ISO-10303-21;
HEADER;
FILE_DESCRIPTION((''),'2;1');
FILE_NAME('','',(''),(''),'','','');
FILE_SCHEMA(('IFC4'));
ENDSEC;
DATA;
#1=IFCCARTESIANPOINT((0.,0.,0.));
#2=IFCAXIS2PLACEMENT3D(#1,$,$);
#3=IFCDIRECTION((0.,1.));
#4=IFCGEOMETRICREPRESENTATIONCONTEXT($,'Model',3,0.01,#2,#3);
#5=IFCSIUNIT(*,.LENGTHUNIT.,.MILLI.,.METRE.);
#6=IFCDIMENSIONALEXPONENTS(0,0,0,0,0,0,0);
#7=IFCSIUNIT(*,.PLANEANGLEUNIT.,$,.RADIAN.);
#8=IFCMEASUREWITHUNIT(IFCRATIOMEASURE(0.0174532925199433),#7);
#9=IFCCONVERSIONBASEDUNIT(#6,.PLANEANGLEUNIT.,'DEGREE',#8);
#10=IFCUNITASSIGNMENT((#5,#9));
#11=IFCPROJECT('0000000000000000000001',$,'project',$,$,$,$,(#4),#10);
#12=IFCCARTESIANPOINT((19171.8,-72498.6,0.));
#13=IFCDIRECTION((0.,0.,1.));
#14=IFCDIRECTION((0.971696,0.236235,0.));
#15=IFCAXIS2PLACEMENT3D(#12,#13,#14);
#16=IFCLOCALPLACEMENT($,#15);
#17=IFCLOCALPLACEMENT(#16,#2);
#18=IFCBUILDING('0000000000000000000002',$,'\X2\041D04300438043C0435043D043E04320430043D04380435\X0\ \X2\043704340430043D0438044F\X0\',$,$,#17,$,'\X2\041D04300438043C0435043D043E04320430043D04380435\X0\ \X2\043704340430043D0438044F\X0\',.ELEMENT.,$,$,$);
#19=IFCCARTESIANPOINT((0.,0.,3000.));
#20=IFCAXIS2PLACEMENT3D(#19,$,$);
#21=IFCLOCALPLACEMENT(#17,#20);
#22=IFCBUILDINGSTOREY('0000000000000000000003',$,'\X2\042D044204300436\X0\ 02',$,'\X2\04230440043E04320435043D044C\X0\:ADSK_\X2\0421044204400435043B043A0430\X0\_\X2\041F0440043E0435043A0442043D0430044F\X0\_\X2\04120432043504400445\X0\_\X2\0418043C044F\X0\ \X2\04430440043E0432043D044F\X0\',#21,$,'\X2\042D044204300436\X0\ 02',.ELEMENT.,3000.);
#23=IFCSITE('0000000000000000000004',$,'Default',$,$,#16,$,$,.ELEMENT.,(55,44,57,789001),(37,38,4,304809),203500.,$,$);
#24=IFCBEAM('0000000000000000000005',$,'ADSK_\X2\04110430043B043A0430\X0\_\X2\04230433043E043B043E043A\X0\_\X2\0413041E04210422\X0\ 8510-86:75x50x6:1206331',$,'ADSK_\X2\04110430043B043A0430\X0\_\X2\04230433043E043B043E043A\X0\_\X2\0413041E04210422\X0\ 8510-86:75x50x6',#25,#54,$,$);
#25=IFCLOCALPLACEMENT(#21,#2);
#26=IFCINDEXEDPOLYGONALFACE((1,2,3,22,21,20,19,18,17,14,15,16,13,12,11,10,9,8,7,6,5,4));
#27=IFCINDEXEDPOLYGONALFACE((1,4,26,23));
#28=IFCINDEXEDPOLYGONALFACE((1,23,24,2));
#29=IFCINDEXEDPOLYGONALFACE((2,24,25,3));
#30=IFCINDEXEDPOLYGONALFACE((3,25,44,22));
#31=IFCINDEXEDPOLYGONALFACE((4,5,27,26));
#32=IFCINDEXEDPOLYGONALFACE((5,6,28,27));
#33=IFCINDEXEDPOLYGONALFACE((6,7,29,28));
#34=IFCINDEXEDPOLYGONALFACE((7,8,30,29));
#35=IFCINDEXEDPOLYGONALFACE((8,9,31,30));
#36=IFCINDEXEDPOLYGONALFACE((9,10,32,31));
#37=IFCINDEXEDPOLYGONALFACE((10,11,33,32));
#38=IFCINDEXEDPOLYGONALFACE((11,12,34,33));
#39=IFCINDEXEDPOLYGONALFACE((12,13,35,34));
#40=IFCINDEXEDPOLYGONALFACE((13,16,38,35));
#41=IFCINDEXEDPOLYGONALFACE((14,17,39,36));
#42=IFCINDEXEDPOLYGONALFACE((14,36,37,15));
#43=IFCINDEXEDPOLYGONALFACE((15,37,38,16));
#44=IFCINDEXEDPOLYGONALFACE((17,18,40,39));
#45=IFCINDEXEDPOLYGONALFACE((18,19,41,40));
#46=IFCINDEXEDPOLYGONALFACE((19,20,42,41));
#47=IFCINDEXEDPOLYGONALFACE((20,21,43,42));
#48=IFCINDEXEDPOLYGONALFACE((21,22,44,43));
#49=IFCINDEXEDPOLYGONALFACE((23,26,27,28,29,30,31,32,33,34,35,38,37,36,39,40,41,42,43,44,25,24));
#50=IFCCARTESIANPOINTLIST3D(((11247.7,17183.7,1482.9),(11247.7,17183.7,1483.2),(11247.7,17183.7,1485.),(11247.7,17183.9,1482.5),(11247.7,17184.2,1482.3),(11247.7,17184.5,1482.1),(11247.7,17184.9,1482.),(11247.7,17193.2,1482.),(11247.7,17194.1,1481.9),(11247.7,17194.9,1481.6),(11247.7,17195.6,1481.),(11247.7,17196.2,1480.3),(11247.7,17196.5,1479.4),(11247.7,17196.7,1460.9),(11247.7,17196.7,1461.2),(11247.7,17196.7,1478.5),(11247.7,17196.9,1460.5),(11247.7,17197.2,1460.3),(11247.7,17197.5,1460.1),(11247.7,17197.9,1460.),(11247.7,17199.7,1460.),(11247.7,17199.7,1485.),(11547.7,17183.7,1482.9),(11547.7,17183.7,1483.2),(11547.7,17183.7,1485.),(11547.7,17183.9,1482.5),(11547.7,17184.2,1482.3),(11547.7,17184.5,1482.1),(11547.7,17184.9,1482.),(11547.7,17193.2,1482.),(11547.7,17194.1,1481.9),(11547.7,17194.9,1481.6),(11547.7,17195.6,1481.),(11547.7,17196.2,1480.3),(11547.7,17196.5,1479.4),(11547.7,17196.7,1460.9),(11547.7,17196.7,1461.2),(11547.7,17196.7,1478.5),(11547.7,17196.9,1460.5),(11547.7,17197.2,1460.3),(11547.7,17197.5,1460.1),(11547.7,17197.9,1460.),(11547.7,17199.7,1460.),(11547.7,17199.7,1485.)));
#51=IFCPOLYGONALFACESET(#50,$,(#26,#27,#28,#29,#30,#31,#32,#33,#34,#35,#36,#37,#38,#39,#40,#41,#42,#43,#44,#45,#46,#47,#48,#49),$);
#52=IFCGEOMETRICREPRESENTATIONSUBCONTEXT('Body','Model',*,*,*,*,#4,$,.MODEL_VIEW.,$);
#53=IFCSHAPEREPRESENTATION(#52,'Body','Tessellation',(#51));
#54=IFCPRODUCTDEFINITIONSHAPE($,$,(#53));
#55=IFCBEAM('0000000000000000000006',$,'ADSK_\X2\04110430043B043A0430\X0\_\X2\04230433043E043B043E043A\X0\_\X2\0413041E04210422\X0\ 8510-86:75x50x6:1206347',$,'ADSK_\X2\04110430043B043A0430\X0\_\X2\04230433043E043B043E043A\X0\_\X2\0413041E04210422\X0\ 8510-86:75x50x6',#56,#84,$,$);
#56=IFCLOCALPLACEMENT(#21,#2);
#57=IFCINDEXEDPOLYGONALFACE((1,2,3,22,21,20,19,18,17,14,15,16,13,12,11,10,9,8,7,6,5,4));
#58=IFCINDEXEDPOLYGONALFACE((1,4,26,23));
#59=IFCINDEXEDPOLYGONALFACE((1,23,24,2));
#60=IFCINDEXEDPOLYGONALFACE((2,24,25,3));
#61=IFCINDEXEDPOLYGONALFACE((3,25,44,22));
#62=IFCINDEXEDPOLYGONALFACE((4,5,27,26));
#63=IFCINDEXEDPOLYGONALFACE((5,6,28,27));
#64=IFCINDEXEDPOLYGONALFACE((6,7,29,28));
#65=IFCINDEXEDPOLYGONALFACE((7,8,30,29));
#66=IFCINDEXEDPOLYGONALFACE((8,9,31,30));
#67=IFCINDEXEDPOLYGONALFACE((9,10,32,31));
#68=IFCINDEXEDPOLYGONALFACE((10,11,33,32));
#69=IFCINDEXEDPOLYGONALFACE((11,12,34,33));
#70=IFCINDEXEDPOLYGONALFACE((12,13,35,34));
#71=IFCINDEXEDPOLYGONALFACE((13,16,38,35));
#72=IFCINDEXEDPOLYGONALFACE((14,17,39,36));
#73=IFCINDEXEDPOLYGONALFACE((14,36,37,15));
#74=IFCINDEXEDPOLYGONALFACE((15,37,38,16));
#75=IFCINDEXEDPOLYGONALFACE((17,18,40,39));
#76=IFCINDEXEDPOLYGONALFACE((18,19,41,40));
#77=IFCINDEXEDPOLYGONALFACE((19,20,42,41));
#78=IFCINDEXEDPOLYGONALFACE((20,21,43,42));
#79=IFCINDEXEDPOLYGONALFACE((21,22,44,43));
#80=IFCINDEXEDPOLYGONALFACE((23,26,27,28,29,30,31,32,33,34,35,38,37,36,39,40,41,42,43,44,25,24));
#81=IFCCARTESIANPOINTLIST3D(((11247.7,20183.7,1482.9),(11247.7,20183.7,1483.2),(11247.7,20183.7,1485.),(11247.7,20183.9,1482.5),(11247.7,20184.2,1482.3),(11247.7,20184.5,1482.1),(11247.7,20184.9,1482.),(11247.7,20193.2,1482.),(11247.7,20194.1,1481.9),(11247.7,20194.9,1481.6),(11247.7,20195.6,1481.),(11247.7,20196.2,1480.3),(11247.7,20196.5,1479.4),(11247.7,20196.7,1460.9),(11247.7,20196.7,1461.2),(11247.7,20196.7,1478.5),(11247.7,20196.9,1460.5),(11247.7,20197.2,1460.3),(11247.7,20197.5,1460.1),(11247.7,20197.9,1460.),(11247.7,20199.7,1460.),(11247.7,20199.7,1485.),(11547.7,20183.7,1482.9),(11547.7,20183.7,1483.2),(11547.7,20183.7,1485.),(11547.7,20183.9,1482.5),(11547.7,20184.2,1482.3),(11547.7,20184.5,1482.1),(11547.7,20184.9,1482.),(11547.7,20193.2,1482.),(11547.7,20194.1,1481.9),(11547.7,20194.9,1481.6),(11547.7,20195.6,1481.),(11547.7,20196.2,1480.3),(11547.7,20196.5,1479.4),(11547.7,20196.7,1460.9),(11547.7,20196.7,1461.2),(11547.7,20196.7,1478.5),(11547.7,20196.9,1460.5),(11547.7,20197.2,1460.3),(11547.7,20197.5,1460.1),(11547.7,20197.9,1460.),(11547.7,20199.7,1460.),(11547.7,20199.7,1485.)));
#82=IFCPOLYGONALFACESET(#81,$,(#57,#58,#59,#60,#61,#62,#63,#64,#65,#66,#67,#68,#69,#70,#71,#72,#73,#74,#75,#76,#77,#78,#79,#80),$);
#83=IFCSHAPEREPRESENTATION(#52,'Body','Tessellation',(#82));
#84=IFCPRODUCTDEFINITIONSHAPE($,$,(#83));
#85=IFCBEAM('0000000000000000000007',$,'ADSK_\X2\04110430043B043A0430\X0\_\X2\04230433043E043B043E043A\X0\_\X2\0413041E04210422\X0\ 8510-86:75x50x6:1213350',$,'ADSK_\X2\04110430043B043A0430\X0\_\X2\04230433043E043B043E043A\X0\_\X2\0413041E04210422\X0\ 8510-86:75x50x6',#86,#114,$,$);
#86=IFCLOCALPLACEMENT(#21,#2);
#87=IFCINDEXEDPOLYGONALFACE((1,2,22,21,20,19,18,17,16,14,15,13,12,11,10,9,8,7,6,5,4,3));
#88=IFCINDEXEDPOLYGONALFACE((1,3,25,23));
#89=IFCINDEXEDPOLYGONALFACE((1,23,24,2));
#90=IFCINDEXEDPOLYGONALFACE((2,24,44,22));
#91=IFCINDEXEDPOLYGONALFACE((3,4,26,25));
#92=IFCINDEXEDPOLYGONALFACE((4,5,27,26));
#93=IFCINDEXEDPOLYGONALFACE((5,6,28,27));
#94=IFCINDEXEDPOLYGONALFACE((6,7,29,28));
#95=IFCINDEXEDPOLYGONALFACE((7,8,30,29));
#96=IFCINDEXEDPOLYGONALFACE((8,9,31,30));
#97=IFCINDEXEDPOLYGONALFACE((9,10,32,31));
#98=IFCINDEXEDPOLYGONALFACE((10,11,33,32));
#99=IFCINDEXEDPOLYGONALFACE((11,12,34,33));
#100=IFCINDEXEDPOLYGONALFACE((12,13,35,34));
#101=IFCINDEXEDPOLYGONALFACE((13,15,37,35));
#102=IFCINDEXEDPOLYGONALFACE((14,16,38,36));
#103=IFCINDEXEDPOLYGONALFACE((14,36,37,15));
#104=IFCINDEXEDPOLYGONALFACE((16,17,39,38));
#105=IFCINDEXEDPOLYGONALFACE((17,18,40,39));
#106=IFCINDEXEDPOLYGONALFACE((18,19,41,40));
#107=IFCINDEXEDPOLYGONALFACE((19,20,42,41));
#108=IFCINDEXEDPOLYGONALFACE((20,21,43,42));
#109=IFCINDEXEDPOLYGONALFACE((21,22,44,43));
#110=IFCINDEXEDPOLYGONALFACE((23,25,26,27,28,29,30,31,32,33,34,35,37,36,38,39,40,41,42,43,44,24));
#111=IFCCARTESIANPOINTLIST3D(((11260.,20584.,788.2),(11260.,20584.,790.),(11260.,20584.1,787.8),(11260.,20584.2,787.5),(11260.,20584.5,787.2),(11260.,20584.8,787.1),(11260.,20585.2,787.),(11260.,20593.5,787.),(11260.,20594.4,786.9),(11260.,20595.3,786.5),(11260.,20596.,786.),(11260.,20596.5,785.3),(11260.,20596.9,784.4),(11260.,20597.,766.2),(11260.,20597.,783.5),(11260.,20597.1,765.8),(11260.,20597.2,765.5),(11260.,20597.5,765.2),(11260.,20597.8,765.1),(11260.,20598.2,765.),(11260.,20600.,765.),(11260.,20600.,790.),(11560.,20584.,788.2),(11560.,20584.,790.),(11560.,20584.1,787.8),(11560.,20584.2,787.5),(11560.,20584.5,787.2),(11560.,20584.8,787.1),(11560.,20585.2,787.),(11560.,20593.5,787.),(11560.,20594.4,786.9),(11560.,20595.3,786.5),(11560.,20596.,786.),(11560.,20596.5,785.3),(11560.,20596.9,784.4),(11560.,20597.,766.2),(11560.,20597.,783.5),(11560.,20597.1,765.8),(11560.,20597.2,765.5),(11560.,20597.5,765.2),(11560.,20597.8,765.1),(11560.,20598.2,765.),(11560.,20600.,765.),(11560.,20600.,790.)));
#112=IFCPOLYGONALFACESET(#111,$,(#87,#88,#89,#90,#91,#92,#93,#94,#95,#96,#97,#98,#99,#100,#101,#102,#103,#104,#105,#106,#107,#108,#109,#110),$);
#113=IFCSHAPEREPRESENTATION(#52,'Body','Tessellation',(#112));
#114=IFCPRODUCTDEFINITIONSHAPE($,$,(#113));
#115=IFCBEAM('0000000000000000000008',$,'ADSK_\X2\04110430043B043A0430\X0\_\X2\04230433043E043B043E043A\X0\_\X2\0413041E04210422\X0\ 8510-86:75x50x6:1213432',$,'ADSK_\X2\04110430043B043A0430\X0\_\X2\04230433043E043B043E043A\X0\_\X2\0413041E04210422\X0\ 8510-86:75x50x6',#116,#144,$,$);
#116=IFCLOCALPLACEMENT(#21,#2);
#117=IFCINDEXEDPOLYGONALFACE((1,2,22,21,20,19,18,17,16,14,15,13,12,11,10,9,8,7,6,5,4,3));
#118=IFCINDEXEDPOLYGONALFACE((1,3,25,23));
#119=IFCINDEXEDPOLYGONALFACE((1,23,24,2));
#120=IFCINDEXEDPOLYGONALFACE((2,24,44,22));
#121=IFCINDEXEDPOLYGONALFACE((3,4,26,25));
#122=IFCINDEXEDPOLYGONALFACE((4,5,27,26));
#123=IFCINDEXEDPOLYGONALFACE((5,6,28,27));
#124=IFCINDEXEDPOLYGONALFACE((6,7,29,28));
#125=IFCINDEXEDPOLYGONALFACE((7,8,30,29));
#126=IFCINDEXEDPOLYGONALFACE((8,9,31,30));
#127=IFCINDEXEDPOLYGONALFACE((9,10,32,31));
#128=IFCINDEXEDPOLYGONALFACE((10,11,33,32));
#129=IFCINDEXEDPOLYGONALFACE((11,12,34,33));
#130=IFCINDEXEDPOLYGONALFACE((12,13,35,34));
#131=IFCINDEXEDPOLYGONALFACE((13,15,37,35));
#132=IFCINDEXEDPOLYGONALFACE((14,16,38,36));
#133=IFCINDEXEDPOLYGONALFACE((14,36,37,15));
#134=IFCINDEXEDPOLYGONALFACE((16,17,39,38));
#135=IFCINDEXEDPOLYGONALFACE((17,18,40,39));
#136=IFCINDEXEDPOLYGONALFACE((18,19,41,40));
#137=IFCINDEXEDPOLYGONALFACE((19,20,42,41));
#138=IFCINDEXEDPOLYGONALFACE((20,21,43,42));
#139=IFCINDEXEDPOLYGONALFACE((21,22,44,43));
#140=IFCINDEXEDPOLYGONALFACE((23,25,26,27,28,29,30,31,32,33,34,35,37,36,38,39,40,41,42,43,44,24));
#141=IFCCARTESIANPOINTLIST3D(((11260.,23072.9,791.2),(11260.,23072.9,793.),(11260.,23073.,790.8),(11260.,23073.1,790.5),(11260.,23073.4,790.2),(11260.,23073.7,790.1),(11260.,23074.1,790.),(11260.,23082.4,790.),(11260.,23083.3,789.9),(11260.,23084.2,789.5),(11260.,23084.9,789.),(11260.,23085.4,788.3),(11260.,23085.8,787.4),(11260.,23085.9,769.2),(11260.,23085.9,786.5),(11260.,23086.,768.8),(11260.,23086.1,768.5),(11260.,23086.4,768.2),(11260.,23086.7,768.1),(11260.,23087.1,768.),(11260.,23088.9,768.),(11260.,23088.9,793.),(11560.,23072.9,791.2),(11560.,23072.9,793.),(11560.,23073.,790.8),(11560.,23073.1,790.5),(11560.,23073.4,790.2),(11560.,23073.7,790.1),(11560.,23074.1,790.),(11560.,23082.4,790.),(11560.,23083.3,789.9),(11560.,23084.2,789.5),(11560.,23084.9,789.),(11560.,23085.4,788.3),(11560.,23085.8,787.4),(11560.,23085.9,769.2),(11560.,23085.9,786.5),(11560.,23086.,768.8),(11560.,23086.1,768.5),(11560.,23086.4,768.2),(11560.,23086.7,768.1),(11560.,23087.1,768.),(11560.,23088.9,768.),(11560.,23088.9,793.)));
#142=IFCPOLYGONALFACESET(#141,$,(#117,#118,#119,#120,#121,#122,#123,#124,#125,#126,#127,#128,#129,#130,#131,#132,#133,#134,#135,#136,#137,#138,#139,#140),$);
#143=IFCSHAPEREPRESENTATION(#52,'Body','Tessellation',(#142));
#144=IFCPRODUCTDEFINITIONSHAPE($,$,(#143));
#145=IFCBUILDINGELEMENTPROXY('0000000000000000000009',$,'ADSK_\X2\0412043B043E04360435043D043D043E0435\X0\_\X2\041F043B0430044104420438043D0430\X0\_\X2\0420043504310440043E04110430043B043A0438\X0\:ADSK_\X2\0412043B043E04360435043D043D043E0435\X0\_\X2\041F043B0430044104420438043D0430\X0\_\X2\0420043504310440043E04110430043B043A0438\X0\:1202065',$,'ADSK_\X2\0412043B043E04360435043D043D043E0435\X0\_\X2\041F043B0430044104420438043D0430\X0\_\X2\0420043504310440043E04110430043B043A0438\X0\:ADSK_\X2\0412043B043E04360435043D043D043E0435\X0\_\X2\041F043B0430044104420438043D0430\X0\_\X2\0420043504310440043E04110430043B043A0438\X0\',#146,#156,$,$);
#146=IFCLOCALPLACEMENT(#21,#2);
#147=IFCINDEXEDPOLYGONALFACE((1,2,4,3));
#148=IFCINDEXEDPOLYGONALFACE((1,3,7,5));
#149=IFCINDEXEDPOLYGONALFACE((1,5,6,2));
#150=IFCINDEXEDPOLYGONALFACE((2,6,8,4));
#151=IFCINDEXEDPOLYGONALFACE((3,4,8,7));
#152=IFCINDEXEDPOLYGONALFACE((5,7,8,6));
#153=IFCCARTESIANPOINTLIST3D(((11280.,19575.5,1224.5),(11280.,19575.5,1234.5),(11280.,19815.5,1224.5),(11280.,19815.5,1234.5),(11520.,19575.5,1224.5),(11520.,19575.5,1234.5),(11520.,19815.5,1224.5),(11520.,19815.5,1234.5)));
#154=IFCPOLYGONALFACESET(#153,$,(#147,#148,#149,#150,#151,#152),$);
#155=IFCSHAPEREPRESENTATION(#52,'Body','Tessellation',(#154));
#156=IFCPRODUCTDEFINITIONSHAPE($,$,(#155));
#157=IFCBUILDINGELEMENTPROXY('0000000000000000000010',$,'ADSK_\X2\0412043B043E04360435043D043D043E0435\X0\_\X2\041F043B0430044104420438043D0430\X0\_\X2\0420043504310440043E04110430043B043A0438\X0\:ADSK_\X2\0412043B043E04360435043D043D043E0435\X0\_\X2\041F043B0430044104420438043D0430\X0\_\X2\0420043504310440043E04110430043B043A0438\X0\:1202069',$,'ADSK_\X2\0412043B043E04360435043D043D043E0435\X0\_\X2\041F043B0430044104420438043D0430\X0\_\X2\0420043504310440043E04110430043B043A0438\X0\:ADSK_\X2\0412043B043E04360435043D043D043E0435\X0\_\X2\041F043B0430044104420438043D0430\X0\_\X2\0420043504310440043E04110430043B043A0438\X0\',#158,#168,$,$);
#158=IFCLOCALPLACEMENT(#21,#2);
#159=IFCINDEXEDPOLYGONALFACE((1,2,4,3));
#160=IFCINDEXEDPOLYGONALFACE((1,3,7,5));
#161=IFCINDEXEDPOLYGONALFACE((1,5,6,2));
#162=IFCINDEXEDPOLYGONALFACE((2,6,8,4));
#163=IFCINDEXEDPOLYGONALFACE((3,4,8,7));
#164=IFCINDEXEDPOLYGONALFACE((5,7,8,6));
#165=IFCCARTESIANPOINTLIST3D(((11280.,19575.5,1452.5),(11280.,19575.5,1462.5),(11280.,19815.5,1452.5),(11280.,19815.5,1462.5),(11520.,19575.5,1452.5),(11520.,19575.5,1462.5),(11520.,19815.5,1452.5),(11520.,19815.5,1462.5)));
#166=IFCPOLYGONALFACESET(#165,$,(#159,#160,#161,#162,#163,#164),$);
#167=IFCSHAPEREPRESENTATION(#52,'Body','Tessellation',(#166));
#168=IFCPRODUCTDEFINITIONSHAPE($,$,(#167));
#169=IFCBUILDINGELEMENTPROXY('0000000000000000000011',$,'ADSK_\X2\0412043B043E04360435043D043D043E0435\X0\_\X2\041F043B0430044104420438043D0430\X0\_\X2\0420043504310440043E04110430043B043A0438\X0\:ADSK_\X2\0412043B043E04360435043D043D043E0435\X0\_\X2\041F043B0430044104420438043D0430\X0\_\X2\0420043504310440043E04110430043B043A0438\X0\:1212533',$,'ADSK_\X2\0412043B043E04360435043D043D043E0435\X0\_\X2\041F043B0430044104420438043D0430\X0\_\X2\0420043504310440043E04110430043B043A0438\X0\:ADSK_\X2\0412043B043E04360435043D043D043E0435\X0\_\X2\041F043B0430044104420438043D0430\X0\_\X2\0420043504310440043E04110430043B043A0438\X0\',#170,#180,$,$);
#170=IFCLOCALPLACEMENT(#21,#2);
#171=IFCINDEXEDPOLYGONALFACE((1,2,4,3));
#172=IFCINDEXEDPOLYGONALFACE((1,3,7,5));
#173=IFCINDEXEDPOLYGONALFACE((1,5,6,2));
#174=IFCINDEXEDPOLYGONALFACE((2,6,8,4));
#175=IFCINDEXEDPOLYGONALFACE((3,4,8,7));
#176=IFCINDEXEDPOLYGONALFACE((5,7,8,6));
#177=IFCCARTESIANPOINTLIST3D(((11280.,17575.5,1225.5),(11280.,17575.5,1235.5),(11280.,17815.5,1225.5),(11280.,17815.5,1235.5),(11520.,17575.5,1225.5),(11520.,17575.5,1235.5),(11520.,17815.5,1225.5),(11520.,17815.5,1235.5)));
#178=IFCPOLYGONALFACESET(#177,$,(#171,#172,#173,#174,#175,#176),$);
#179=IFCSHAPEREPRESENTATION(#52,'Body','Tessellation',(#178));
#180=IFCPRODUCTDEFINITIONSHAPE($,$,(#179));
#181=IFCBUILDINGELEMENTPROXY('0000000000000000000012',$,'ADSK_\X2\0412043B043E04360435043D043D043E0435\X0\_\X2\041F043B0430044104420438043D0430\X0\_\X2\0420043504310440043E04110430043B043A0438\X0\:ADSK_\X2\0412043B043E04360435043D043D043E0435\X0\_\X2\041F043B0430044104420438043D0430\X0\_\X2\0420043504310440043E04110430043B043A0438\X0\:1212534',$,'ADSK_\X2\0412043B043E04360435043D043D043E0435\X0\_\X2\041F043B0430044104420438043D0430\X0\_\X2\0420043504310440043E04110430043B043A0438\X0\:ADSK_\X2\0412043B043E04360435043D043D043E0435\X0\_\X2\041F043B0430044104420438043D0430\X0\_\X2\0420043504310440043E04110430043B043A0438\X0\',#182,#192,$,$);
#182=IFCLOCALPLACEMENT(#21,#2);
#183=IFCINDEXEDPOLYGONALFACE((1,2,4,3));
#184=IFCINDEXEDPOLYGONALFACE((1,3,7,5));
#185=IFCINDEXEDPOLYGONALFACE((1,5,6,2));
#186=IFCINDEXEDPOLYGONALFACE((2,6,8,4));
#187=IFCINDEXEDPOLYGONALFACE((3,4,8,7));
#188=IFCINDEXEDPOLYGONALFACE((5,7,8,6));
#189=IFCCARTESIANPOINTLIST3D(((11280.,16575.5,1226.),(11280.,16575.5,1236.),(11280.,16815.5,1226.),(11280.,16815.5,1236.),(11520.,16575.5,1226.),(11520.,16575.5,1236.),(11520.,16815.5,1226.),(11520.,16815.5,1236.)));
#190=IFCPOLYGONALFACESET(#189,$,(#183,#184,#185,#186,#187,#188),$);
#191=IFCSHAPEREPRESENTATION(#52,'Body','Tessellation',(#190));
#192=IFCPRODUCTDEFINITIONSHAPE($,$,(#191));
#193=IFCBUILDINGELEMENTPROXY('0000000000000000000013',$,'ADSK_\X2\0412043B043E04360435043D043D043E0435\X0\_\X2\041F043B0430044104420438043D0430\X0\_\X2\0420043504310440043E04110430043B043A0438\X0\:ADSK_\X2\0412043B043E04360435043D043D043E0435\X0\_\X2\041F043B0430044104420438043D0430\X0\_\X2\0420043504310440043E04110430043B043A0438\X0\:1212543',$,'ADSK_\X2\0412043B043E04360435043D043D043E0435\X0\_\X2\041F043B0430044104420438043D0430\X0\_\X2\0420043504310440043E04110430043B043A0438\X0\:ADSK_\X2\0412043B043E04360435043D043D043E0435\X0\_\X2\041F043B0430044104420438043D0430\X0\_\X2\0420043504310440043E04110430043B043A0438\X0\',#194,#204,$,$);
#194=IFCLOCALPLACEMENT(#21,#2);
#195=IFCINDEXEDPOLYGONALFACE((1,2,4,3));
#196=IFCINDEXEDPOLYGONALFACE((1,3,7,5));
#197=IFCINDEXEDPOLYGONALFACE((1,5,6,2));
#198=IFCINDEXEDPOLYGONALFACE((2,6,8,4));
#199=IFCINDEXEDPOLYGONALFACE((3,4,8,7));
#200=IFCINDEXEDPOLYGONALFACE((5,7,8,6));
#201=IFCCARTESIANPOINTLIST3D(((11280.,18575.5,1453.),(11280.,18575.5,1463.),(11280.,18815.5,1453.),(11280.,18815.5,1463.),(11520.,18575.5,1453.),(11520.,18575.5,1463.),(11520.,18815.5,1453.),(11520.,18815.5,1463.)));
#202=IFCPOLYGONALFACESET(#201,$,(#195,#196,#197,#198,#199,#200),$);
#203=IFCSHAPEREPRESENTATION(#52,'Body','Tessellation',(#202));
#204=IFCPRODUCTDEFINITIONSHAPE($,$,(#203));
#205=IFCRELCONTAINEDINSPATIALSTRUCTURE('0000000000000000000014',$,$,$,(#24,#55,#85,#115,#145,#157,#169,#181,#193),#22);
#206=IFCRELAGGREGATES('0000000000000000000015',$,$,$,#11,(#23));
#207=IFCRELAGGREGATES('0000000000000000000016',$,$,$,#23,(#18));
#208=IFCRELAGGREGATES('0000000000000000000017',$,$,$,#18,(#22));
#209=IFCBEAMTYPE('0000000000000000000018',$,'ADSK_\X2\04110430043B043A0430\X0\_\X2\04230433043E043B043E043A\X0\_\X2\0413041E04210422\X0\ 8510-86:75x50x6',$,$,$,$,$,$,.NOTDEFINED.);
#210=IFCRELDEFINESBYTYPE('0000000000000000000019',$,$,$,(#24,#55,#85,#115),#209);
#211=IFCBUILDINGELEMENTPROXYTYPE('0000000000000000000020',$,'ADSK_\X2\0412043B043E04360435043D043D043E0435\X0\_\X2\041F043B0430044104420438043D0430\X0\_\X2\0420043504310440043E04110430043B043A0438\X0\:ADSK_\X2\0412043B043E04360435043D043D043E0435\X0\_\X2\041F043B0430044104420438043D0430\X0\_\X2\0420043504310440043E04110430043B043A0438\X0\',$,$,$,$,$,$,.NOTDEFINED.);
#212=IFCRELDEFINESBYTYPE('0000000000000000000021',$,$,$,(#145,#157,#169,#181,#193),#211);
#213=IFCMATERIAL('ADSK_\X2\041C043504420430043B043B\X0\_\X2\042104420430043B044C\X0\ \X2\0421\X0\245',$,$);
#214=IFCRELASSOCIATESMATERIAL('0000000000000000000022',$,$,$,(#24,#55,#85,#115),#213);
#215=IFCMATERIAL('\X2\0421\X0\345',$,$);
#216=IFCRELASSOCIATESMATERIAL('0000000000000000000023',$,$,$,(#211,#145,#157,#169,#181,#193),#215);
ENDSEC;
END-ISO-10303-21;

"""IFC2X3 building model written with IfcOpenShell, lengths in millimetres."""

from ifc_helpers import new_model, entity, si_unit, converted_unit, direction, frame, frame_2d, origin, origin_2d_with_axis, place, context, subcontext, project, spatial, polyline, circle_curve, parameter, trimmed, segment, composite_curve, rectangle, outline, extrude, source, transform, mapped, material, type_object, type_shapes, element, save


model = new_model("IFC2X3")

# Units and contexts
model_context = context("Model", 3, precision=0.01, world=origin(), true_north=direction((0.0, 1.0)))
body_context = subcontext(model_context, "Body", "Model", "MODEL_VIEW")
ifc_project = project(units=[si_unit("LENGTHUNIT", "METRE", prefix="MILLI"), converted_unit("PLANEANGLEUNIT", "DEGREE", entity("IfcRatioMeasure", 0.0174532925199433), si_unit("PLANEANGLEUNIT", "RADIAN"), dimensions=[0, 0, 0, 0, 0, 0, 0])], contexts=[model_context])

# Site, building, storey
site_placement = place(None, frame((19171.8, -72498.6, 0.0), z_axis=(0.0, 0.0, 1.0), x_axis=(0.971696, 0.236235, 0.0)))
site = spatial("IfcSite", under=ifc_project, at=site_placement, Name="Default", CompositionType="ELEMENT", RefLatitude=(55, 44, 57, 789001), RefLongitude=(37, 38, 4, 304809), RefElevation=203500.0)
building_placement = place(site_placement, origin())
building = spatial("IfcBuilding", under=site, at=building_placement, Name="Наименование здания", LongName="Наименование здания", CompositionType="ELEMENT")
storey_placement = place(building_placement, frame((0.0, 0.0, 3000.0)))
storey = spatial("IfcBuildingStorey", under=building, at=storey_placement, Name="Этаж 02", ObjectType="Уровень:ADSK_Стрелка_Проектная_Вверх_Имя уровня", LongName="Этаж 02", CompositionType="ELEMENT", Elevation=3000.0)

# Beams
ifc_material_1 = material(Name="ADSK_Металл_Сталь С245")
beam_type_1 = type_object("IfcBeamType", Name="ADSK_Балка_Уголок_ГОСТ 8510-86:75x50x6", PredefinedType="NOTDEFINED")
beam_1_placement = place(storey_placement, frame((11247.7, 17195.5, 1460.0)))
element("IfcBeam", 1, at=beam_1_placement, inside=storey, type_object=beam_type_1, material=ifc_material_1, Name="ADSK_Балка_Уголок_ГОСТ 8510-86:75x50x6:1206331", ObjectType="ADSK_Балка_Уголок_ГОСТ 8510-86:75x50x6", context=body_context, shape_type="SweptSolid", body=[
    extrude(outline(composite_curve([segment(polyline([(-9.8, -9.2), (-8.0, -9.2)]), True, "CONTINUOUS"), segment(trimmed(circle_curve(frame_2d((-8.0, -8.0), x_axis=(0.0, -1.0)), 1.2), [parameter(0.0)], [parameter(90.0)], True, "PARAMETER"), True, "CONTINUOUS"), segment(polyline([(-6.8, -8.0), (-6.8, 0.3)]), True, "CONTINUOUS"), segment(trimmed(circle_curve(frame_2d((-3.3, 0.3), x_axis=(-1.0, 0.0)), 3.5), [parameter(270.0)], [parameter(0.0)], True, "PARAMETER"), False, "CONTINUOUS"), segment(polyline([(-3.3, 3.8), (14.0, 3.8)]), True, "CONTINUOUS"), segment(trimmed(circle_curve(frame_2d((14.0, 5.0), x_axis=(0.0, -1.0)), 1.2), [parameter(0.0)], [parameter(90.0)], True, "PARAMETER"), True, "CONTINUOUS"), segment(polyline([(15.2, 5.0), (15.2, 6.8)]), True, "CONTINUOUS"), segment(polyline([(15.2, 6.8), (-9.8, 6.8)]), True, "CONTINUOUS"), segment(polyline([(-9.8, 6.8), (-9.8, -9.2)]), True, "CONTINUOUS")], self_intersect=False)), frame((0.0, -2.6, 15.2), z_axis=(1.0, 0.0, 0.0), x_axis=(0.0, 0.0, -1.0)), (0.0, 0.0, 1.0), 300.0),
])
for number, where, name in (
    (2, (11247.7, 20195.5, 1460.0), "ADSK_Балка_Уголок_ГОСТ 8510-86:75x50x6:1206347"),
    (3, (11260.0, 20595.8, 765.0), "ADSK_Балка_Уголок_ГОСТ 8510-86:75x50x6:1213350"),
    (4, (11260.0, 23084.7, 768.0), "ADSK_Балка_Уголок_ГОСТ 8510-86:75x50x6:1213432"),
):
    element("IfcBeam", number, at=place(storey_placement, frame(where)), inside=storey, type_object=beam_type_1, material=ifc_material_1, Name=name, ObjectType="ADSK_Балка_Уголок_ГОСТ 8510-86:75x50x6", context=body_context, shape_type="SweptSolid", body=[
        extrude(outline(composite_curve([segment(polyline([(-9.8, -9.2), (-8.0, -9.2)]), True, "CONTINUOUS"), segment(trimmed(circle_curve(frame_2d((-8.0, -8.0), x_axis=(0.0, -1.0)), 1.2), [parameter(0.0)], [parameter(90.0)], True, "PARAMETER"), True, "CONTINUOUS"), segment(polyline([(-6.8, -8.0), (-6.8, 0.3)]), True, "CONTINUOUS"), segment(trimmed(circle_curve(frame_2d((-3.3, 0.3), x_axis=(-1.0, 0.0)), 3.5), [parameter(270.0)], [parameter(0.0)], True, "PARAMETER"), False, "CONTINUOUS"), segment(polyline([(-3.3, 3.8), (14.0, 3.8)]), True, "CONTINUOUS"), segment(trimmed(circle_curve(frame_2d((14.0, 5.0), x_axis=(0.0, -1.0)), 1.2), [parameter(0.0)], [parameter(90.0)], True, "PARAMETER"), True, "CONTINUOUS"), segment(polyline([(15.2, 5.0), (15.2, 6.8)]), True, "CONTINUOUS"), segment(polyline([(15.2, 6.8), (-9.8, 6.8)]), True, "CONTINUOUS"), segment(polyline([(-9.8, 6.8), (-9.8, -9.2)]), True, "CONTINUOUS")], self_intersect=False)), frame((0.0, -2.6, 15.2), z_axis=(1.0, 0.0, 0.0), x_axis=(0.0, 0.0, -1.0)), (0.0, 0.0, 1.0), 300.0),
    ])

# Building element proxies
ifc_material_2 = material(Name="С345")
building_element_proxy_type = type_object("IfcBuildingElementProxyType", Name="ADSK_Вложенное_Пластина_РеброБалки:ADSK_Вложенное_Пластина_РеброБалки", PredefinedType="NOTDEFINED", material=ifc_material_2)
shared_shape = source(origin(), body_context, "Body", "SweptSolid", [
    extrude(rectangle(XDim=10.0, YDim=240.0, at=origin_2d_with_axis()), frame((0.0, 0.0, -120.0), z_axis=(0.0, 0.0, 1.0), x_axis=(0.0, 1.0, 0.0)), (0.0, 0.0, 1.0), 240.0),
])
type_shapes(building_element_proxy_type, [shared_shape])
for number, where, z_axis, x_axis, name in (
    (5, (11400.0, 19695.5, 1229.5), (0.0, 1.0, 0.0), (1.0, 0.0, 0.0), "ADSK_Вложенное_Пластина_РеброБалки:ADSK_Вложенное_Пластина_РеброБалки:1202065"),
    (6, (11400.0, 19695.5, 1457.5), (0.0, 1.0, 0.0), (1.0, 0.0, 0.0), "ADSK_Вложенное_Пластина_РеброБалки:ADSK_Вложенное_Пластина_РеброБалки:1202069"),
    (7, (11400.0, 17695.5, 1230.5), (0.0, 1.0, 0.0), (1.0, 0.0, 0.0), "ADSK_Вложенное_Пластина_РеброБалки:ADSK_Вложенное_Пластина_РеброБалки:1212533"),
    (8, (11400.0, 16695.5, 1231.0), (0.0, 1.0, 0.0), (1.0, 0.0, 0.0), "ADSK_Вложенное_Пластина_РеброБалки:ADSK_Вложенное_Пластина_РеброБалки:1212534"),
    (9, (11400.0, 18695.5, 1458.0), (0.0, 1.0, 0.0), (1.0, 0.0, 0.0), "ADSK_Вложенное_Пластина_РеброБалки:ADSK_Вложенное_Пластина_РеброБалки:1212543"),
):
    element("IfcBuildingElementProxy", number, at=place(storey_placement, frame(where, z_axis=z_axis, x_axis=x_axis)), inside=storey, type_object=building_element_proxy_type, material=ifc_material_2, Name=name, ObjectType="ADSK_Вложенное_Пластина_РеброБалки:ADSK_Вложенное_Пластина_РеброБалки", context=body_context, shape_type="MappedRepresentation", body=[
        mapped(shared_shape, transform((0.0, 0.0, 0.0), scale=1.0)),
    ])

save(model, "model.ifc")
